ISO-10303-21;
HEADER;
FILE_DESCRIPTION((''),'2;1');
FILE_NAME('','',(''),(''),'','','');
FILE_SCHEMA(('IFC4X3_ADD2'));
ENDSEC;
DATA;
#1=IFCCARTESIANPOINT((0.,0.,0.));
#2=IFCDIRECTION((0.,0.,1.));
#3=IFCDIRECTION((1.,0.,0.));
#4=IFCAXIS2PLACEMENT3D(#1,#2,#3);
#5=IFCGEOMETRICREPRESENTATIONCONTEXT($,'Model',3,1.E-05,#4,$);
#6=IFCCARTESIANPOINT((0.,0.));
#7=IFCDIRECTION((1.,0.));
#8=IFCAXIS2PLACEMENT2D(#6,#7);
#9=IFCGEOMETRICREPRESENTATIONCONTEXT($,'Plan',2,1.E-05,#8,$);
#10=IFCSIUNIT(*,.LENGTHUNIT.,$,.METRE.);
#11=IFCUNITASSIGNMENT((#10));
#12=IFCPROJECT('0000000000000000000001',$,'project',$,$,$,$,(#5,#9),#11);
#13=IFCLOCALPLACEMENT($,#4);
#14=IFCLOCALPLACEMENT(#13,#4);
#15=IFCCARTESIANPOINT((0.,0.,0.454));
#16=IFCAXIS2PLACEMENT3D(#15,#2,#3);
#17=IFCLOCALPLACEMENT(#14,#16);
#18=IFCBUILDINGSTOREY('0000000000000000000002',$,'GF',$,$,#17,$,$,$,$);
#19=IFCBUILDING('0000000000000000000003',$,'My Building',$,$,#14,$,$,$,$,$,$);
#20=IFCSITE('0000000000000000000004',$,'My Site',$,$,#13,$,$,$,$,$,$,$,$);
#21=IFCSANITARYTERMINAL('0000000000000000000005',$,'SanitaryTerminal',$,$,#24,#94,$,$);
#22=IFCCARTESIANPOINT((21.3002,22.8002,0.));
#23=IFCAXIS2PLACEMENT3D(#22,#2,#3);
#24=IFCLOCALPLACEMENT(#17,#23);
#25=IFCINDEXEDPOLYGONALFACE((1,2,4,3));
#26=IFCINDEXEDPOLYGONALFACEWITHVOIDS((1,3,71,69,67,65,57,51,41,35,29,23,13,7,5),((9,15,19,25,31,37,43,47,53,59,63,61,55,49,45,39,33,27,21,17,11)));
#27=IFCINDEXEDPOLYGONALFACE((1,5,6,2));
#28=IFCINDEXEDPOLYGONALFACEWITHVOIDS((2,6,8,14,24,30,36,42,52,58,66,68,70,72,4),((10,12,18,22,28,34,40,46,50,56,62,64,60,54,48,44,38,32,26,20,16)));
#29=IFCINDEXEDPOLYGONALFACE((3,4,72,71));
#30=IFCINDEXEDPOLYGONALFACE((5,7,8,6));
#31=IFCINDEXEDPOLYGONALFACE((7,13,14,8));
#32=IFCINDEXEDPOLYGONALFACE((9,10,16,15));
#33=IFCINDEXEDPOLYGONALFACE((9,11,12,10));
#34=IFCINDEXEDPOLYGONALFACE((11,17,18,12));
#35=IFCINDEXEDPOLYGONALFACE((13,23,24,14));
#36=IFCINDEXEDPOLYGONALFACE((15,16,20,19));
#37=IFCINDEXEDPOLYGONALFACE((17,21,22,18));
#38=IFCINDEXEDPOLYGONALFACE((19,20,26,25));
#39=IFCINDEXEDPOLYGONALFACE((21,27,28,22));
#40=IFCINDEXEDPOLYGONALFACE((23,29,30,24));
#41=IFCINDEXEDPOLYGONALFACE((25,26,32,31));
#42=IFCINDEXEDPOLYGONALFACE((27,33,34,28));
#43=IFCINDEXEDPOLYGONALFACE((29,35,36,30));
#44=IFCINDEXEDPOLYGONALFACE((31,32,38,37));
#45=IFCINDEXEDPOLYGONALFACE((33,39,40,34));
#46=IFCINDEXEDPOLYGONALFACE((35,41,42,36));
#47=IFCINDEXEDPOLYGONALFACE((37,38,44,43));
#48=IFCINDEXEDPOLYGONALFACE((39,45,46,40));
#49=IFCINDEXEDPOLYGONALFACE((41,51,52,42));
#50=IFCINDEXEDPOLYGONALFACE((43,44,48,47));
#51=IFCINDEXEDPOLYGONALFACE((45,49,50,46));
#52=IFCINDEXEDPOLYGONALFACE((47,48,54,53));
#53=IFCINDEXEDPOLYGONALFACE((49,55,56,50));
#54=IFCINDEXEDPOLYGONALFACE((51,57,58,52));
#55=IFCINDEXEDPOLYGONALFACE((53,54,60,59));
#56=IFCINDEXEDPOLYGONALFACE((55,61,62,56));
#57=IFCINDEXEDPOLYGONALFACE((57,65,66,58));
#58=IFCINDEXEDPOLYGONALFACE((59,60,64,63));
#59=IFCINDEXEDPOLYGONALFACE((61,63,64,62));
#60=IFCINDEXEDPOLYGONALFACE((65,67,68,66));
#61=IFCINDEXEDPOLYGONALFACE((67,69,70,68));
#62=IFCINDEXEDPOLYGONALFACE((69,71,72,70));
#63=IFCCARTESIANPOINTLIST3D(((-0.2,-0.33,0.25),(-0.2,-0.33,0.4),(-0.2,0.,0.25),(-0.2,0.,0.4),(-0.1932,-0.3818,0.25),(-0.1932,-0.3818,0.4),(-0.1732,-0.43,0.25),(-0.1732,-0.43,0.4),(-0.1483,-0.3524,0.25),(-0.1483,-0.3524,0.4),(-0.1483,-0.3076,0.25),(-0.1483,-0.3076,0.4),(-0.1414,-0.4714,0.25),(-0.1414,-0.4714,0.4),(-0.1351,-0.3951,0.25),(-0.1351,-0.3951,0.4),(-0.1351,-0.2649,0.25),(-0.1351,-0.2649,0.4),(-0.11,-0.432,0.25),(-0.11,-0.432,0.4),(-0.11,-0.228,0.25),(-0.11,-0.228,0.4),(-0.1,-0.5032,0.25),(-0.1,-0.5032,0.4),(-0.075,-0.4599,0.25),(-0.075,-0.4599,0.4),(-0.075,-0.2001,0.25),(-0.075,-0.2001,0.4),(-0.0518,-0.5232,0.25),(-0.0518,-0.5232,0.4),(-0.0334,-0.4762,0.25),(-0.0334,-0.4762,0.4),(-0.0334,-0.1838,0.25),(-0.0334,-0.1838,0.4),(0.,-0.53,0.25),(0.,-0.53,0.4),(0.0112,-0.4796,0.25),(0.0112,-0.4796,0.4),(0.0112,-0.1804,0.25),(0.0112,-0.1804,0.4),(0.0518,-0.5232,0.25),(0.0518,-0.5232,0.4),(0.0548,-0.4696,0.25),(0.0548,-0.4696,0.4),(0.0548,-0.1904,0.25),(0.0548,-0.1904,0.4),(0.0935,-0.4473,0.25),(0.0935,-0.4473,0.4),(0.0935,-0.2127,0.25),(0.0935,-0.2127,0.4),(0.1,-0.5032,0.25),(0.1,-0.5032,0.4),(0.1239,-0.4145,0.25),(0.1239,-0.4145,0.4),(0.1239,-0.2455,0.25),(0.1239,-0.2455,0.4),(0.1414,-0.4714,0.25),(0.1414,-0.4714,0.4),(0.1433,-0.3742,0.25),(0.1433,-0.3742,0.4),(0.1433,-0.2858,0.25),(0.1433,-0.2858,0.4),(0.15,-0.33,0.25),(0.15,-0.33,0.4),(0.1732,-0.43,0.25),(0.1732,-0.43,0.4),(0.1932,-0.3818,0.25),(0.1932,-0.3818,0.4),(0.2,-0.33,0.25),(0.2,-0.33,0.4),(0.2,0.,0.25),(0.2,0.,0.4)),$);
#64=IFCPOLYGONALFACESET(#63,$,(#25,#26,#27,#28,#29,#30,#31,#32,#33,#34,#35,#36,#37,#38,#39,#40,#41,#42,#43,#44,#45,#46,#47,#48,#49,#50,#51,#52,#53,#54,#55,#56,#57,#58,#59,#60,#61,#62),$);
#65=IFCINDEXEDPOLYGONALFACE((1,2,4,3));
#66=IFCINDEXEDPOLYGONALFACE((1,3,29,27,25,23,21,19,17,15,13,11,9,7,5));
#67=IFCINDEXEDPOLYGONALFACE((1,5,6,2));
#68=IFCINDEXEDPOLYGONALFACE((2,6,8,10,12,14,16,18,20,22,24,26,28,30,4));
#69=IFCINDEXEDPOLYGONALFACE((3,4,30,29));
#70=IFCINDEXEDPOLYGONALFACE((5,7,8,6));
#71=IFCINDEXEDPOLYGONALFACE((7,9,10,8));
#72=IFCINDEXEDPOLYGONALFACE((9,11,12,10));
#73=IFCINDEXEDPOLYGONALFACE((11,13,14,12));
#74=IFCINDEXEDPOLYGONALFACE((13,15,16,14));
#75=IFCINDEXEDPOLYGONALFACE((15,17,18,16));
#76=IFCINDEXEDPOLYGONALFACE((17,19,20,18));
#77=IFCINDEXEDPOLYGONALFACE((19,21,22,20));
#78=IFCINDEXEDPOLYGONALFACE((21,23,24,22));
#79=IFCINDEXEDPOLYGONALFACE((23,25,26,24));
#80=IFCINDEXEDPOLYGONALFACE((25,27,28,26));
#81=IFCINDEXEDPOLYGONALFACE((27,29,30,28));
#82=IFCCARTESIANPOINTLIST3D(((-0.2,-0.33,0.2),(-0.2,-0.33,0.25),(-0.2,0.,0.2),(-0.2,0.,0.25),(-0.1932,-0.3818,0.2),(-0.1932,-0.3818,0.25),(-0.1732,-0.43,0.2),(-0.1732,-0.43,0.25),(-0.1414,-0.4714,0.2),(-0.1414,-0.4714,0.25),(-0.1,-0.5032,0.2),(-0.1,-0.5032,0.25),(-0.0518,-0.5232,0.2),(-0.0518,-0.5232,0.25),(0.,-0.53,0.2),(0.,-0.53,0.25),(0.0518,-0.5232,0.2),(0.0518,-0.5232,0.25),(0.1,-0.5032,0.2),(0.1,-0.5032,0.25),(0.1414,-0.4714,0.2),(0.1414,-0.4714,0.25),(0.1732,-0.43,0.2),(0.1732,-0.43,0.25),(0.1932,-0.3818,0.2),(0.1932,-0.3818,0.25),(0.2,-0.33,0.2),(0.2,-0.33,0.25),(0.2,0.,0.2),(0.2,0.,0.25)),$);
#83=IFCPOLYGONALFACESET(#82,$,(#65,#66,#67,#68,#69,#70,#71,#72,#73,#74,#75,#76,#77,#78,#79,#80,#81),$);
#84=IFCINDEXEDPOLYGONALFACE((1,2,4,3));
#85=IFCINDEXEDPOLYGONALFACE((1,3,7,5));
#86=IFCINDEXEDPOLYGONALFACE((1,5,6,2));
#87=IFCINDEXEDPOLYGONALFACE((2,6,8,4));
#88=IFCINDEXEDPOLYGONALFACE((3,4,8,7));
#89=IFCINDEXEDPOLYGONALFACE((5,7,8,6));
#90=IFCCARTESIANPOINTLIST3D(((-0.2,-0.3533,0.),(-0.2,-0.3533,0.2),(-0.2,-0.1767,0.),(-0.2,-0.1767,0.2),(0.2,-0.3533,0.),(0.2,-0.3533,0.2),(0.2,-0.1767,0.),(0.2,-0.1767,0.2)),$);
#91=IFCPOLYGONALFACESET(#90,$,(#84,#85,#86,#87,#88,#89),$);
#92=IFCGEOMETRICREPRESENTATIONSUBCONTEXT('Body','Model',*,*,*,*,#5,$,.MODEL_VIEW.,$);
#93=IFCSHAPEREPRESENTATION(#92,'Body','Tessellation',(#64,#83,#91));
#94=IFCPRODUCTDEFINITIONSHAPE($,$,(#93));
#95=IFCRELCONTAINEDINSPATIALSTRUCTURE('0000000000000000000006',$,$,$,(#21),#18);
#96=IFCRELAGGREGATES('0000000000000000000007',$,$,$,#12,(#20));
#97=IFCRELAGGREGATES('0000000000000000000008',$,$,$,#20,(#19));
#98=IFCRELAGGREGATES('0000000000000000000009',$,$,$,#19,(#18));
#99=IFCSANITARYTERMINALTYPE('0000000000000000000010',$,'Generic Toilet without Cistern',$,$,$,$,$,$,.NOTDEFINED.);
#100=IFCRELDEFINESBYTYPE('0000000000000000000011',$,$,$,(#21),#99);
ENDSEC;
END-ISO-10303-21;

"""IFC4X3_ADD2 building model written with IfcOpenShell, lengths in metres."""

from ifc_helpers import new_model, entity, si_unit, frame, frame_2d, origin_with_axes, origin_2d_with_axis, place, context, subcontext, project, spatial, line, arc, indexed_curve, circle_curve, outline, extrude, shape, source, transform, mapped, type_object, type_shapes, element, save


model = new_model("IFC4X3_ADD2")

# Units and contexts
model_context = context("Model", 3, precision=1e-05, world=origin_with_axes())
plan_context = context("Plan", 2, precision=1e-05, world=origin_2d_with_axis())
body_context_1 = subcontext(model_context, "Body", "Model", "MODEL_VIEW")
body_context_2 = subcontext(plan_context, "Body", "Plan", "PLAN_VIEW")
ifc_project = project(units=[si_unit("LENGTHUNIT", "METRE")], contexts=[model_context, plan_context])

# Site, building, storey
site_placement = place(None, origin_with_axes())
site = spatial("IfcSite", under=ifc_project, at=site_placement, Name="My Site")
building_placement = place(site_placement, origin_with_axes())
building = spatial("IfcBuilding", under=site, at=building_placement, Name="My Building")
storey_placement = place(building_placement, frame((0.0, 0.0, 0.454), z_axis=(0.0, 0.0, 1.0), x_axis=(1.0, 0.0, 0.0)))
storey = spatial("IfcBuildingStorey", under=building, at=storey_placement, Name="GF")

# Sanitary terminal
sanitary_terminal_type_1 = type_object("IfcSanitaryTerminalType", Name="Generic Toilet without Cistern", PredefinedType="NOTDEFINED")
shared_shape_1 = source(origin_with_axes(), body_context_1, "Body", "SweptSolid", [
    extrude(outline(indexed_curve([(-0.2, 0.0), (0.2, 0.0), (0.2, -0.33), (0.1414, -0.4714), (0.0, -0.53), (-0.1414, -0.4714), (-0.2, -0.33)], segments=[line(1, 2), line(2, 3), arc(3, 4, 5), arc(5, 6, 7), line(7, 1)]), holes=[circle_curve(frame_2d((0.0, -0.33)), 0.15)]), frame((0.0, 0.0, 0.25), z_axis=(0.0, 0.0, 1.0), x_axis=(1.0, 0.0, 0.0)), (0.0, 0.0, 1.0), 0.15),
    extrude(outline(indexed_curve([(-0.2, 0.0), (0.2, 0.0), (0.2, -0.33), (0.1414, -0.4714), (0.0, -0.53), (-0.1414, -0.4714), (-0.2, -0.33)], segments=[line(1, 2), line(2, 3), arc(3, 4, 5), arc(5, 6, 7), line(7, 1)])), frame((0.0, 0.0, 0.2), z_axis=(0.0, 0.0, 1.0), x_axis=(1.0, 0.0, 0.0)), (0.0, 0.0, 1.0), 0.05),
    extrude(outline(indexed_curve([(-0.2, -0.1767), (0.2, -0.1767), (0.2, -0.3533), (-0.2, -0.3533)], segments=[line(1, 2, 3, 4, 1)])), origin_with_axes(), (0.0, 0.0, 1.0), 0.2),
])
shared_shape_2 = source(origin_with_axes(), body_context_2, "Body", "Annotation2D", [
    entity("IfcGeometricCurveSet", [entity("IfcIndexedPolyCurve", entity("IfcCartesianPointList2D", [[-0.1068, -0.124], [-0.0957, -0.1129], [-0.0804, -0.1088], [0.0804, -0.1088], [0.0957, -0.1129], [0.1068, -0.124], [0.1109, -0.1393], [0.1109, -0.3476], [0.1025, -0.3926], [0.0784, -0.4308], [0.0424, -0.4563], [0.0, -0.4652], [-0.0424, -0.4563], [-0.0784, -0.4308], [-0.1025, -0.3926], [-0.1109, -0.3476], [-0.1109, -0.1393]]), [entity("IfcLineIndex", [1, 2, 3, 4, 5, 6, 7, 8, 9, 10, 11, 12, 13, 14, 15, 16, 17, 1])]), entity("IfcIndexedPolyCurve", entity("IfcCartesianPointList2D", [[-0.1962, -0.2314], [-0.1848, -0.301], [-0.1764, -0.3339], [-0.1663, -0.3651], [-0.1546, -0.3944], [-0.1414, -0.4213], [-0.1269, -0.4458], [-0.1111, -0.4675], [-0.0943, -0.4862], [-0.0765, -0.5018], [-0.0581, -0.514], [-0.039, -0.5229], [-0.0196, -0.5282], [0.0, -0.53], [0.0196, -0.5282], [0.039, -0.5229], [0.0581, -0.514], [0.0765, -0.5018], [0.0943, -0.4862], [0.1111, -0.4675], [0.1269, -0.4458], [0.1414, -0.4213], [0.1546, -0.3944], [0.1663, -0.3651], [0.1764, -0.3339], [0.1848, -0.301], [0.1962, -0.2314], [0.2, -0.159], [0.1872, 0.0], [-0.1872, 0.0], [-0.2, -0.159]]), [entity("IfcLineIndex", [1, 2, 3, 4, 5, 6, 7, 8, 9, 10, 11, 12, 13, 14, 15, 16, 17, 18, 19, 20, 21, 22, 23, 24, 25, 26, 27, 28, 29, 30, 31, 1])])]),
])
type_shapes(sanitary_terminal_type_1, [shared_shape_1, shared_shape_2])
sanitary_terminal_1_placement = place(storey_placement, frame((21.3002, 22.8002, 0.0), z_axis=(0.0, 0.0, 1.0), x_axis=(1.0, 0.0, 0.0)))
element("IfcSanitaryTerminal", 1, at=sanitary_terminal_1_placement, inside=storey, type_object=sanitary_terminal_type_1, Name="SanitaryTerminal", shapes=[
    shape(body_context_1, "Body", "MappedRepresentation", [mapped(shared_shape_1, transform((0.0, 0.0, 0.0), x_axis=(1.0, 0.0, 0.0), y_axis=(0.0, 1.0, 0.0), z_axis=(0.0, 0.0, 1.0), scale=1.0))]),
    shape(body_context_2, "Body", "MappedRepresentation", [mapped(shared_shape_2, transform((0.0, 0.0, 0.0), x_axis=(1.0, 0.0, 0.0), y_axis=(0.0, 1.0, 0.0), z_axis=(0.0, 0.0, 1.0), scale=1.0))]),
])

save(model, "model.ifc")
